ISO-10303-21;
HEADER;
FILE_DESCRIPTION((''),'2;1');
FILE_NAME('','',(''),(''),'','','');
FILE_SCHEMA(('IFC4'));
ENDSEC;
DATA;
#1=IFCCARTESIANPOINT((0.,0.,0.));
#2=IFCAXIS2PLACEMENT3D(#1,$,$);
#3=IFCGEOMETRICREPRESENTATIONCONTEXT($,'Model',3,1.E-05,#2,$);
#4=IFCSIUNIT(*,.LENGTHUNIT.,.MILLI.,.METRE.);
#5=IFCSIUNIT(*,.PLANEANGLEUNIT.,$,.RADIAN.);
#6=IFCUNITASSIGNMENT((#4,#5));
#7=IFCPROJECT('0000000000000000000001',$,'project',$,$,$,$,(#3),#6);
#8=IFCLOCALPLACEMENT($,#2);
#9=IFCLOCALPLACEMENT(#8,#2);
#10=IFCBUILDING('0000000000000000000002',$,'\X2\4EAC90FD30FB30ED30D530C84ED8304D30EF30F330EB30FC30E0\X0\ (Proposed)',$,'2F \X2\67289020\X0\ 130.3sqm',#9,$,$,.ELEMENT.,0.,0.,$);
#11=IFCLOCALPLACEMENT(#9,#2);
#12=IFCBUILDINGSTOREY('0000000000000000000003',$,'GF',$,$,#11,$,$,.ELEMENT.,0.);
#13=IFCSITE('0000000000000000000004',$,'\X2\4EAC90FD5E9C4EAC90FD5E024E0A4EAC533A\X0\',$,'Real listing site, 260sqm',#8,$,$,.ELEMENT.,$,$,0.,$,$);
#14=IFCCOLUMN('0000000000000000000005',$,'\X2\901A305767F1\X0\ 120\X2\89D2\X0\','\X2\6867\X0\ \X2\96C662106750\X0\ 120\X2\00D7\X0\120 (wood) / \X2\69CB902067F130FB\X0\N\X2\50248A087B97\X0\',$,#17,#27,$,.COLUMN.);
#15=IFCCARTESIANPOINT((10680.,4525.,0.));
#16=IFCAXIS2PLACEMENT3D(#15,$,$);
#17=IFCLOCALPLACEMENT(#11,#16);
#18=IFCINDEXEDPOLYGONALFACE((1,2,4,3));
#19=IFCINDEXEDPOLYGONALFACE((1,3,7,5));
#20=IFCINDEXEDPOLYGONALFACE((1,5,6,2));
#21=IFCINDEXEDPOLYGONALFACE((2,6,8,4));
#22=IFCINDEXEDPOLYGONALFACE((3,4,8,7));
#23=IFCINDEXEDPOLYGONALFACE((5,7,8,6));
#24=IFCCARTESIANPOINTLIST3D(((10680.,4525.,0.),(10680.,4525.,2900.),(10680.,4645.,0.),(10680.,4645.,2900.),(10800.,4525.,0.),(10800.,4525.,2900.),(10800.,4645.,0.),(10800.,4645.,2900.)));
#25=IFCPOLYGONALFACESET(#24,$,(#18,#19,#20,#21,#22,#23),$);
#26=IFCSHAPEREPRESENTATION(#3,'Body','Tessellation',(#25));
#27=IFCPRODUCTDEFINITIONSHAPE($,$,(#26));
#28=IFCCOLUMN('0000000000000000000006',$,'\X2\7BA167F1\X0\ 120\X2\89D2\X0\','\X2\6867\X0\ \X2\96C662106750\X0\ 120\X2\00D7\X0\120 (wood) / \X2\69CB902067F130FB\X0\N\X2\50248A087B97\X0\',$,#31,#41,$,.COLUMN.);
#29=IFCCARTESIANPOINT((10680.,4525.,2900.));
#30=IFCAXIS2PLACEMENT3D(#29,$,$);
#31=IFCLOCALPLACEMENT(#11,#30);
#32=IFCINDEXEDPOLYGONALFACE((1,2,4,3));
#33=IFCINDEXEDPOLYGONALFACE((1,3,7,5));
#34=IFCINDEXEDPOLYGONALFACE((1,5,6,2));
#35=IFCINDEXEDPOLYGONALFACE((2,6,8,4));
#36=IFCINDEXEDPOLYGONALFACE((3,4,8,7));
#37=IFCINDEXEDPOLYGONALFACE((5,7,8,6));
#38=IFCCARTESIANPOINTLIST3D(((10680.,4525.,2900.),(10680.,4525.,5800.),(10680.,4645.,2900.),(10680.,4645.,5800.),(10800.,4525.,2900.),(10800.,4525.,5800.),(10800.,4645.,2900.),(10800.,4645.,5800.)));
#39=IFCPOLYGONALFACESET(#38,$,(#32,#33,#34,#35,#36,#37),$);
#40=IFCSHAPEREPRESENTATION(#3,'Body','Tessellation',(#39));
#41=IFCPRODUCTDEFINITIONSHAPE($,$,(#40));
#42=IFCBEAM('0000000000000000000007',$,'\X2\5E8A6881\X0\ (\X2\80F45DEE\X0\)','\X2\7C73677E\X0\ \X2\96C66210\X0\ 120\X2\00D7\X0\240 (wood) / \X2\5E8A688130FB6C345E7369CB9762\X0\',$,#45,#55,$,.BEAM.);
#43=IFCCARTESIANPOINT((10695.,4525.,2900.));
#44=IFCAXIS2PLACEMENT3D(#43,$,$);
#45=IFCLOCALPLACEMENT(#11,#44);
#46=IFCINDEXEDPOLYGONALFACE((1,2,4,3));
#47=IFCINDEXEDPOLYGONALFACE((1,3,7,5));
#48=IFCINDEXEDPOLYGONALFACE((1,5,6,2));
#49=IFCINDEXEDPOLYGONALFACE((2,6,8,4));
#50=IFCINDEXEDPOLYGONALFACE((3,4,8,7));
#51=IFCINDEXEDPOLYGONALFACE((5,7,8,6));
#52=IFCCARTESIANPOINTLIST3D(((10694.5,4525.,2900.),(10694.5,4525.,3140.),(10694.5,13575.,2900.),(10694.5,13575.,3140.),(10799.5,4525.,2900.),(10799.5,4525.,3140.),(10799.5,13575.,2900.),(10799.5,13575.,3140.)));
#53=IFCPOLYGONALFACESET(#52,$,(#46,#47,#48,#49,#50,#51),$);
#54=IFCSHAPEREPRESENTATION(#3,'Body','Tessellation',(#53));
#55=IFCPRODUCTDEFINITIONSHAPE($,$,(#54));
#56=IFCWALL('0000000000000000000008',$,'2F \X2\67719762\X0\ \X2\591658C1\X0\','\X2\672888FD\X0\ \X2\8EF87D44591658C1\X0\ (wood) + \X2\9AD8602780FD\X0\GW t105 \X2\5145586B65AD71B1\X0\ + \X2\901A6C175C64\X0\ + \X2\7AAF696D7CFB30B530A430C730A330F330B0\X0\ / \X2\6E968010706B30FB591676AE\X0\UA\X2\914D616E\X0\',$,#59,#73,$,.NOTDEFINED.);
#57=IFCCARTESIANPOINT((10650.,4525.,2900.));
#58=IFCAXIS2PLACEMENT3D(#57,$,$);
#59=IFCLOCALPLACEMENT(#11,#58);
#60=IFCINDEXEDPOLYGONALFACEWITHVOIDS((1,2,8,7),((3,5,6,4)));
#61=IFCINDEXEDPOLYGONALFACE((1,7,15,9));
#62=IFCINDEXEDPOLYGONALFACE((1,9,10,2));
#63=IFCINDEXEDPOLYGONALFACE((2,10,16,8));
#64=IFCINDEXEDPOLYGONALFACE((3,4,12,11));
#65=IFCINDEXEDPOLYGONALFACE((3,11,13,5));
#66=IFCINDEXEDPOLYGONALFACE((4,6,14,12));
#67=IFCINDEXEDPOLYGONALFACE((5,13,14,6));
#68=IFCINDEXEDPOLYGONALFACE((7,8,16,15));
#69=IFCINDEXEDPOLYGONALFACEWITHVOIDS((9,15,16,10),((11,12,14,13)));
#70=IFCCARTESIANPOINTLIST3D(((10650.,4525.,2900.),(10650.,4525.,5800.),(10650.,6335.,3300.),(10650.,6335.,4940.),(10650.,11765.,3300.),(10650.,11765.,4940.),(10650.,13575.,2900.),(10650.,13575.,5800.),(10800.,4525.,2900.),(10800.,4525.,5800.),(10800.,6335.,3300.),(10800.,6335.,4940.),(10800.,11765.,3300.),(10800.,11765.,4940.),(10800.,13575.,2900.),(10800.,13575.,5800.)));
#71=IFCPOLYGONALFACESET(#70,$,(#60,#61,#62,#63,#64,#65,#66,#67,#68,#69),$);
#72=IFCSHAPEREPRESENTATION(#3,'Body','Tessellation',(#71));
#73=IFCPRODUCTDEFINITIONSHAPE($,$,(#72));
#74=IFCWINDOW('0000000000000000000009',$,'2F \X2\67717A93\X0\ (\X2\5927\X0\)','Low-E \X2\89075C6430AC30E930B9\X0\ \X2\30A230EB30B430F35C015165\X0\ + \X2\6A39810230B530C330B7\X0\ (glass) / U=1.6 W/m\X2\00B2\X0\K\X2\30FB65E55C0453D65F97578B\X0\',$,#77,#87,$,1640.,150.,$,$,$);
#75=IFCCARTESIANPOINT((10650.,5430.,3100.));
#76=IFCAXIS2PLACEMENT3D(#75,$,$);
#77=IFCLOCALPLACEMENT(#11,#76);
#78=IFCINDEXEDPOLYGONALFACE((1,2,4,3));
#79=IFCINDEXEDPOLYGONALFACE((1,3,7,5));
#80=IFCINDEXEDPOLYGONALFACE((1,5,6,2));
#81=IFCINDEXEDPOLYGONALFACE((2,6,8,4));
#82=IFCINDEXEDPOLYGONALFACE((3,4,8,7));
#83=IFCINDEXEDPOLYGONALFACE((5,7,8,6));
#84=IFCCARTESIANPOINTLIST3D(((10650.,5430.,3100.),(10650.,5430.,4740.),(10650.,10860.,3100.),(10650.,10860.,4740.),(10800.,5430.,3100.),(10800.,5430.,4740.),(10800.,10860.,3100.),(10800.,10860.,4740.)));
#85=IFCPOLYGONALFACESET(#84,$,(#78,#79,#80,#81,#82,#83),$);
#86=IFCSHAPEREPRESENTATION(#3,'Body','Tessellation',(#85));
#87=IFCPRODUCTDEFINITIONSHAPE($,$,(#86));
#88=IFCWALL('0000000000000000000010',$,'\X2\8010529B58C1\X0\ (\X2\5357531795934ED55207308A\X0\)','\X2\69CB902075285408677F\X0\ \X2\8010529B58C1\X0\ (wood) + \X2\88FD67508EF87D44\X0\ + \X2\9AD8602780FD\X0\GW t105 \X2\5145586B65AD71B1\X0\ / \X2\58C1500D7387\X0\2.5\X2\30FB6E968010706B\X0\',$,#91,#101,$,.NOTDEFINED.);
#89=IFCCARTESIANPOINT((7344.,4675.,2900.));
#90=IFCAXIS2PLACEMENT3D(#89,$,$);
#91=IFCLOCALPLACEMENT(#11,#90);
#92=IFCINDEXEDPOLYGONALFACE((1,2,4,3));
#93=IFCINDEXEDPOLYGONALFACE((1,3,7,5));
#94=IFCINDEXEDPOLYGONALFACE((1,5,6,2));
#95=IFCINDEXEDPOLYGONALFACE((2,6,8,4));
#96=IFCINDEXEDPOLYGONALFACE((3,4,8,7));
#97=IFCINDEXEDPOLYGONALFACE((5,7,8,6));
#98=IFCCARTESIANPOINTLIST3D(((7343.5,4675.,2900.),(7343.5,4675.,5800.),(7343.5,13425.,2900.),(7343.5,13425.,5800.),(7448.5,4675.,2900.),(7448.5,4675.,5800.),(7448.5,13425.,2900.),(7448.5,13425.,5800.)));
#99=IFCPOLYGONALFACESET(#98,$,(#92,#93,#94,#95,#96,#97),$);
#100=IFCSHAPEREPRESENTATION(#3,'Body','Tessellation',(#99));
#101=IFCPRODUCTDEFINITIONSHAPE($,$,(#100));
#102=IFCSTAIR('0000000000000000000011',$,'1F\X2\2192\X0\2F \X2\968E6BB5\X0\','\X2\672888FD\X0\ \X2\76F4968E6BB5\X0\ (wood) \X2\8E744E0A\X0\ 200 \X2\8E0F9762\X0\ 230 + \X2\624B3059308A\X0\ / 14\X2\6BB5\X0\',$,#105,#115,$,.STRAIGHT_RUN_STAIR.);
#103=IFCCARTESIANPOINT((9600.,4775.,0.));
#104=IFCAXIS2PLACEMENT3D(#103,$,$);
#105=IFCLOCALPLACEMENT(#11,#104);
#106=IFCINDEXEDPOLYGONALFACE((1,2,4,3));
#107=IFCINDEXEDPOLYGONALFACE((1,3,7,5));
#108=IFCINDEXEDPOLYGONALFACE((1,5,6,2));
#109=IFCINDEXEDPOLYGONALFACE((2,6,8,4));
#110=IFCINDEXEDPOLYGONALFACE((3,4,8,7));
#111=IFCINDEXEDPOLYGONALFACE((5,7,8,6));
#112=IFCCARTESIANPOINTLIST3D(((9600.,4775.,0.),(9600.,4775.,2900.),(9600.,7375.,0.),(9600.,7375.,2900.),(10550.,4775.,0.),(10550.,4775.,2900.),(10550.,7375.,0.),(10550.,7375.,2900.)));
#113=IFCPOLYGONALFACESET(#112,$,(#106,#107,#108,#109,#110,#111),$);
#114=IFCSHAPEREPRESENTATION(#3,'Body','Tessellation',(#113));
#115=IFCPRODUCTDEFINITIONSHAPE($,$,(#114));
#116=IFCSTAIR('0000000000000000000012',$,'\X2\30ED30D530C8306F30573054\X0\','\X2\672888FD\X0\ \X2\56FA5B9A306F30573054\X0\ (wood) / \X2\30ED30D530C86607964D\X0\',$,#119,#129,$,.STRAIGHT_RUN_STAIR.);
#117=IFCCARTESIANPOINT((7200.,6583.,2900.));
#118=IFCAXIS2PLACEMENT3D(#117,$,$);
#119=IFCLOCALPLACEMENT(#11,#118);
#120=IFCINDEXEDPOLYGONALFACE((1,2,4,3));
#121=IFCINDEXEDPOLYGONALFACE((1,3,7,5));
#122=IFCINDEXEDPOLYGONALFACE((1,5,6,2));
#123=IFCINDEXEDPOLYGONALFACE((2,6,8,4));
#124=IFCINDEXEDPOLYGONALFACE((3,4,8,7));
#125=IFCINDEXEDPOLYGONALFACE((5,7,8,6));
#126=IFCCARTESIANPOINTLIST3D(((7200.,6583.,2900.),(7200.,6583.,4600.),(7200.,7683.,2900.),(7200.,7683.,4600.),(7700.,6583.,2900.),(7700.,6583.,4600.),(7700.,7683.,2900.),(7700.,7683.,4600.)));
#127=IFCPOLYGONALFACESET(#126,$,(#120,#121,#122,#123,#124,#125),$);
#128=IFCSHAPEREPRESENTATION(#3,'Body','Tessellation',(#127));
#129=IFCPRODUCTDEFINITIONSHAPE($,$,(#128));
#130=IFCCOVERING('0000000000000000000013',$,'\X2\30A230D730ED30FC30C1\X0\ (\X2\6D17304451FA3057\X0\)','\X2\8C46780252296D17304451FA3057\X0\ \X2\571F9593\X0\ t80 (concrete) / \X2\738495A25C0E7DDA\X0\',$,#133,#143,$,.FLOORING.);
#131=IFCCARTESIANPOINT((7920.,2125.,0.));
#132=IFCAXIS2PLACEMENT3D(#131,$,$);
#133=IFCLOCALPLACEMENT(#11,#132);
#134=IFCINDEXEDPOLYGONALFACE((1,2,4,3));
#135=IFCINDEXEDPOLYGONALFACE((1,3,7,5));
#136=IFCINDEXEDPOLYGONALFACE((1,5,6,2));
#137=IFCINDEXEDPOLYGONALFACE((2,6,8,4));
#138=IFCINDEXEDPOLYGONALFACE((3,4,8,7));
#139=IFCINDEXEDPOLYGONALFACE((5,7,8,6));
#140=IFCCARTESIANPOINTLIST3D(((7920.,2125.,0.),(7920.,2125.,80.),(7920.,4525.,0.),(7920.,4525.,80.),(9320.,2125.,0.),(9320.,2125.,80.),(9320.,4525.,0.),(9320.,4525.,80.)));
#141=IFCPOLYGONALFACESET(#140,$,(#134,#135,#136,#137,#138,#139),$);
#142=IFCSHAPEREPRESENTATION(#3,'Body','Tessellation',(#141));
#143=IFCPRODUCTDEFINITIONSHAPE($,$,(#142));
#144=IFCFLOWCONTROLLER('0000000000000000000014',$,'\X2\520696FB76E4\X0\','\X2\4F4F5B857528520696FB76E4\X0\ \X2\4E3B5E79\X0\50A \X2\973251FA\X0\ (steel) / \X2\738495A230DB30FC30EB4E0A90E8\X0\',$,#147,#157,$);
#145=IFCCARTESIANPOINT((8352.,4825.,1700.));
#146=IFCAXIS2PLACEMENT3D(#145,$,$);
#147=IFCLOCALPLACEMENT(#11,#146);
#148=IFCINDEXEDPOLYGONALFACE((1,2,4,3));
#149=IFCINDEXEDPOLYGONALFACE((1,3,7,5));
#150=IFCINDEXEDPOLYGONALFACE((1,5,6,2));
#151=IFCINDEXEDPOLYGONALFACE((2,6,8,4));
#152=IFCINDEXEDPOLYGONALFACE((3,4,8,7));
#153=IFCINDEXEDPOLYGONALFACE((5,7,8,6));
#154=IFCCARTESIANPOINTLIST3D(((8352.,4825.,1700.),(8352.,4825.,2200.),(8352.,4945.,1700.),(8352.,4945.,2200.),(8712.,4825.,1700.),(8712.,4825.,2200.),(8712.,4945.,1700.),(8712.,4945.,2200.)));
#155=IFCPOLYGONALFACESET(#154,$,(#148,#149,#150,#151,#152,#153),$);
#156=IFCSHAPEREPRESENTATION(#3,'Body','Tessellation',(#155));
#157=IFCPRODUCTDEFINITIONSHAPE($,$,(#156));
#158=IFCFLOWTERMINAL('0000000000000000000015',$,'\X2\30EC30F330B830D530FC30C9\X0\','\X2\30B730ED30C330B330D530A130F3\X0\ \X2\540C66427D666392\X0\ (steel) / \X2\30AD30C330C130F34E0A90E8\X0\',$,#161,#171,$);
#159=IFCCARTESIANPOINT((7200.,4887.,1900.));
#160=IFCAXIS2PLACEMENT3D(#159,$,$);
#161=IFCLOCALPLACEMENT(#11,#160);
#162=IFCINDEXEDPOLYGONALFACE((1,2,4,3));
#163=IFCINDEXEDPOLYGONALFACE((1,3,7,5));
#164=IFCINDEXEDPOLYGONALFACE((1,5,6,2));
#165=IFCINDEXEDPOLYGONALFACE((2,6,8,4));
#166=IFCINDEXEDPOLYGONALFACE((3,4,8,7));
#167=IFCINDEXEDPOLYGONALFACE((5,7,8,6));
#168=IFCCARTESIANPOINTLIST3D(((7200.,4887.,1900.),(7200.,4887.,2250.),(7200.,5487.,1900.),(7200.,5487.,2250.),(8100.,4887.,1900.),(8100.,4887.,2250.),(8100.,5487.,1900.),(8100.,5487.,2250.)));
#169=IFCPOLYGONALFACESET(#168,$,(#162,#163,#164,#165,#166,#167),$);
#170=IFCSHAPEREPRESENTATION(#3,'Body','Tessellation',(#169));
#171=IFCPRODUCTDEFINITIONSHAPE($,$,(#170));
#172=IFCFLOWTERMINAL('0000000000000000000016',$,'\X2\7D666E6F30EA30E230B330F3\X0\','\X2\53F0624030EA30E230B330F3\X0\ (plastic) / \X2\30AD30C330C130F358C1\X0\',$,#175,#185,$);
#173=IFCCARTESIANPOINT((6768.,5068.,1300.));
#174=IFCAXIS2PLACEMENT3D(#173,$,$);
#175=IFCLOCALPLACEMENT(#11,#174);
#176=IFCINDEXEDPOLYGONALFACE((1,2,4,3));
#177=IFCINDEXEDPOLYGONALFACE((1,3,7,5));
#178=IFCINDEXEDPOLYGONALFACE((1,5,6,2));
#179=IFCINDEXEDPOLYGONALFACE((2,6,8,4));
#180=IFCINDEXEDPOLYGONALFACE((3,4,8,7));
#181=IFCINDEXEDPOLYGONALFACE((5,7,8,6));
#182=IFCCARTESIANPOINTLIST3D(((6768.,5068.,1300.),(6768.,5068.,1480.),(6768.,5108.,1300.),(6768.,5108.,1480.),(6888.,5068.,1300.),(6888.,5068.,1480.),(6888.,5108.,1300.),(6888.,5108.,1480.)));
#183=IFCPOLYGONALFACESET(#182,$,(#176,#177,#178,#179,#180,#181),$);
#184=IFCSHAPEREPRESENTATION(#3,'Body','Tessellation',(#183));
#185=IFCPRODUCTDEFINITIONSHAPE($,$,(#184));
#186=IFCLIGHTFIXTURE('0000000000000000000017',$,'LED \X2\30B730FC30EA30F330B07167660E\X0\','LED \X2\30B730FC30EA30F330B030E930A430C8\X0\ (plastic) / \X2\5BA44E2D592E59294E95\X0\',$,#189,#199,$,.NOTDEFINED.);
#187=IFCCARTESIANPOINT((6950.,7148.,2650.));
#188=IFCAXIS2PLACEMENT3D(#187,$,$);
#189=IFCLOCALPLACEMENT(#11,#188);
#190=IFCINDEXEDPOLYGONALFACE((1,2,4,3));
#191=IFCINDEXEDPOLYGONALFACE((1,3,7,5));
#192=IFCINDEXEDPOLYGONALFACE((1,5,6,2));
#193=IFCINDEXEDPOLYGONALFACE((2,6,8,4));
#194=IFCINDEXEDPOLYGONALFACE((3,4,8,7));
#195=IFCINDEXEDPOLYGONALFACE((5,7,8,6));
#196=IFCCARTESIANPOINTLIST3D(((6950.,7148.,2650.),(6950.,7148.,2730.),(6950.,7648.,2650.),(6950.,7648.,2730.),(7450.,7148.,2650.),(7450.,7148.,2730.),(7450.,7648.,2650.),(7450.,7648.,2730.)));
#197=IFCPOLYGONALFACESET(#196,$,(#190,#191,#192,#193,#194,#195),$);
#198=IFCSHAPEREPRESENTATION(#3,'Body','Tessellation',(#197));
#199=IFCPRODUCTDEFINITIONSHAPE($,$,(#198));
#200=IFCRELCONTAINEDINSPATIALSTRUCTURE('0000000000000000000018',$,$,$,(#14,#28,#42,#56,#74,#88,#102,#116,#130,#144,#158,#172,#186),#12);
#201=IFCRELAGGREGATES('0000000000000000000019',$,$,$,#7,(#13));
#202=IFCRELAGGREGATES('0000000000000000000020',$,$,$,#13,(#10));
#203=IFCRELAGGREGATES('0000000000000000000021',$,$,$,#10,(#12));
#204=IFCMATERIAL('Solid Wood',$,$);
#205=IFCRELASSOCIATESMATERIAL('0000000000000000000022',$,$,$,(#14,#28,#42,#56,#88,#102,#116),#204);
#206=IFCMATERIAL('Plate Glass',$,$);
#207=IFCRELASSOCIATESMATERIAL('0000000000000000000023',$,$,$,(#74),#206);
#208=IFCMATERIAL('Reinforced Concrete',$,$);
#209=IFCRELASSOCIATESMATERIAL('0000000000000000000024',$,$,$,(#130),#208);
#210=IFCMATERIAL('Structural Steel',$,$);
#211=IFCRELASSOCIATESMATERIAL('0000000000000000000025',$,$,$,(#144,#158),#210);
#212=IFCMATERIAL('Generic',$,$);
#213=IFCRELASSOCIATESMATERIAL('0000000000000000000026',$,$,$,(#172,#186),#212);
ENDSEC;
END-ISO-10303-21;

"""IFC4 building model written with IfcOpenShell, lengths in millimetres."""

from ifc_helpers import new_model, si_unit, frame, frame_2d, origin, place, context, project, spatial, rectangle, extrude, material, element, fill, save


model = new_model("IFC4")

# Units and contexts
model_context = context("Model", 3, precision=1e-05, world=origin())
ifc_project = project(units=[si_unit("LENGTHUNIT", "METRE", prefix="MILLI"), si_unit("PLANEANGLEUNIT", "RADIAN")], contexts=[model_context])

# Site, building, storey
site_placement = place(None, origin())
site = spatial("IfcSite", under=ifc_project, at=site_placement, Name="京都府京都市上京区", ObjectType="Real listing site, 260sqm", CompositionType="ELEMENT", RefElevation=0.0)
building_placement = place(site_placement, origin())
building = spatial("IfcBuilding", under=site, at=building_placement, Name="京都・ロフト付きワンルーム (Proposed)", ObjectType="2F 木造 130.3sqm", CompositionType="ELEMENT", ElevationOfRefHeight=0.0, ElevationOfTerrain=0.0)
storey_placement = place(building_placement, origin())
storey = spatial("IfcBuildingStorey", under=building, at=storey_placement, Name="GF", CompositionType="ELEMENT", Elevation=0.0)

# Columns
ifc_material_1 = material(Name="Solid Wood")
column_1_placement = place(storey_placement, frame((10680.0, 4525.0, 0.0)))
element("IfcColumn", 1, at=column_1_placement, inside=storey, material=ifc_material_1, Name="通し柱 120角", Description="桧 集成材 120×120 (wood) / 構造柱・N値計算", PredefinedType="COLUMN", context=model_context, shape_type="SweptSolid", body=[
    extrude(rectangle(XDim=120.0, YDim=120.0, at=frame_2d((60.0, 60.0))), frame((10680.0, 4525.0, 0.0)), (0.0, 0.0, 1.0), 2900.0),
])
column_2_placement = place(storey_placement, frame((10680.0, 4525.0, 2900.0)))
element("IfcColumn", 2, at=column_2_placement, inside=storey, material=ifc_material_1, Name="管柱 120角", Description="桧 集成材 120×120 (wood) / 構造柱・N値計算", PredefinedType="COLUMN", context=model_context, shape_type="SweptSolid", body=[
    extrude(rectangle(XDim=120.0, YDim=120.0, at=frame_2d((60.0, 60.0))), frame((10680.0, 4525.0, 2900.0)), (0.0, 0.0, 1.0), 2900.0),
])

# Beam
beam_1_placement = place(storey_placement, frame((10695.0, 4525.0, 2900.0)))
element("IfcBeam", 3, at=beam_1_placement, inside=storey, material=ifc_material_1, Name="床梁 (胴差)", Description="米松 集成 120×240 (wood) / 床梁・水平構面", PredefinedType="BEAM", context=model_context, shape_type="SweptSolid", body=[
    extrude(rectangle(XDim=105.0, YDim=9050.0, at=frame_2d((52.0, 4525.0))), frame((10695.0, 4525.0, 2900.0)), (0.0, 0.0, 1.0), 240.0),
])

# Shared definitions
ifc_material_2 = material(Name="Plate Glass")

# Wall, opening, window
wall_1_placement = place(storey_placement, frame((10650.0, 4525.0, 2900.0)))
wall_1 = element("IfcWall", 4, at=wall_1_placement, inside=storey, material=ifc_material_1, Name="2F 東面 外壁", Description="木製 軸組外壁 (wood) + 高性能GW t105 充填断熱 + 通気層 + 窯業系サイディング / 準耐火・外皮UA配慮", PredefinedType="NOTDEFINED", context=model_context, shape_type="SweptSolid", body=[
    extrude(rectangle(XDim=150.0, YDim=9050.0, at=frame_2d((75.0, 4525.0))), frame((10650.0, 4525.0, 2900.0)), (0.0, 0.0, 1.0), 2900.0),
])
opening_1_placement = place(storey_placement, frame((10650.0, 5430.0, 3100.0)))
opening_1 = element("IfcOpeningElement", 5, at=opening_1_placement, cuts=wall_1, PredefinedType="NOTDEFINED", context=model_context, shape_type="SweptSolid", body=[
    extrude(rectangle(XDim=150.0, YDim=5430.0, at=frame_2d((75.0, 2715.0))), frame((10650.0, 5430.0, 3100.0)), (0.0, 0.0, 1.0), 1640.0),
])
window_1_placement = place(storey_placement, frame((10650.0, 5430.0, 3100.0)))
window_1 = element("IfcWindow", 6, at=window_1_placement, inside=storey, material=ifc_material_2, Name="2F 東窓 (大)", Description="Low-E 複層ガラス アルゴン封入 + 樹脂サッシ (glass) / U=1.6 W/m²K・日射取得型", OverallHeight=1640.0, OverallWidth=150.0, context=model_context, shape_type="SweptSolid", body=[
    extrude(rectangle(XDim=150.0, YDim=5430.0, at=frame_2d((75.0, 2715.0))), frame((10650.0, 5430.0, 3100.0)), (0.0, 0.0, 1.0), 1640.0),
])
fill(opening_1, window_1)

# Wall
wall_2_placement = place(storey_placement, frame((7344.0, 4675.0, 2900.0)))
element("IfcWall", 7, at=wall_2_placement, inside=storey, material=ifc_material_1, Name="耐力壁 (南北間仕切り)", Description="構造用合板 耐力壁 (wood) + 製材軸組 + 高性能GW t105 充填断熱 / 壁倍率2.5・準耐火", PredefinedType="NOTDEFINED", context=model_context, shape_type="SweptSolid", body=[
    extrude(rectangle(XDim=105.0, YDim=8750.0, at=frame_2d((52.0, 4375.0))), frame((7344.0, 4675.0, 2900.0)), (0.0, 0.0, 1.0), 2900.0),
])

# Stairs
stair_1_placement = place(storey_placement, frame((9600.0, 4775.0, 0.0)))
element("IfcStair", 8, at=stair_1_placement, inside=storey, material=ifc_material_1, Name="1F→2F 階段", Description="木製 直階段 (wood) 蹴上 200 踏面 230 + 手すり / 14段", PredefinedType="STRAIGHT_RUN_STAIR", context=model_context, shape_type="SweptSolid", body=[
    extrude(rectangle(XDim=950.0, YDim=2600.0, at=frame_2d((475.0, 1300.0))), frame((9600.0, 4775.0, 0.0)), (0.0, 0.0, 1.0), 2900.0),
])
stair_2_placement = place(storey_placement, frame((7200.0, 6583.0, 2900.0)))
element("IfcStair", 9, at=stair_2_placement, inside=storey, material=ifc_material_1, Name="ロフトはしご", Description="木製 固定はしご (wood) / ロフト昇降", PredefinedType="STRAIGHT_RUN_STAIR", context=model_context, shape_type="SweptSolid", body=[
    extrude(rectangle(XDim=500.0, YDim=1100.0, at=frame_2d((250.0, 550.0))), frame((7200.0, 6583.0, 2900.0)), (0.0, 0.0, 1.0), 1700.0),
])

# Covering
ifc_material_3 = material(Name="Reinforced Concrete")
covering_placement = place(storey_placement, frame((7920.0, 2125.0, 0.0)))
element("IfcCovering", 10, at=covering_placement, inside=storey, material=ifc_material_3, Name="アプローチ (洗い出し)", Description="豆砂利洗い出し 土間 t80 (concrete) / 玄関導線", PredefinedType="FLOORING", context=model_context, shape_type="SweptSolid", body=[
    extrude(rectangle(XDim=1400.0, YDim=2400.0, at=frame_2d((700.0, 1200.0))), frame((7920.0, 2125.0, 0.0)), (0.0, 0.0, 1.0), 80.0),
])

# Flow controller
ifc_material_4 = material(Name="Structural Steel")
flow_controller_placement = place(storey_placement, frame((8352.0, 4825.0, 1700.0)))
element("IfcFlowController", 11, at=flow_controller_placement, inside=storey, material=ifc_material_4, Name="分電盤", Description="住宅用分電盤 主幹50A 露出 (steel) / 玄関ホール上部", context=model_context, shape_type="SweptSolid", body=[
    extrude(rectangle(XDim=360.0, YDim=120.0, at=frame_2d((180.0, 60.0))), frame((8352.0, 4825.0, 1700.0)), (0.0, 0.0, 1.0), 500.0),
])

# Flow terminals
flow_terminal_1_placement = place(storey_placement, frame((7200.0, 4887.0, 1900.0)))
element("IfcFlowTerminal", 12, at=flow_terminal_1_placement, inside=storey, material=ifc_material_4, Name="レンジフード", Description="シロッコファン 同時給排 (steel) / キッチン上部", context=model_context, shape_type="SweptSolid", body=[
    extrude(rectangle(XDim=900.0, YDim=600.0, at=frame_2d((450.0, 300.0))), frame((7200.0, 4887.0, 1900.0)), (0.0, 0.0, 1.0), 350.0),
])
ifc_material_5 = material(Name="Generic")
flow_terminal_2_placement = place(storey_placement, frame((6768.0, 5068.0, 1300.0)))
element("IfcFlowTerminal", 13, at=flow_terminal_2_placement, inside=storey, material=ifc_material_5, Name="給湯リモコン", Description="台所リモコン (plastic) / キッチン壁", context=model_context, shape_type="SweptSolid", body=[
    extrude(rectangle(XDim=120.0, YDim=40.0, at=frame_2d((60.0, 20.0))), frame((6768.0, 5068.0, 1300.0)), (0.0, 0.0, 1.0), 180.0),
])

# Light fixture
light_fixture_1_placement = place(storey_placement, frame((6950.0, 7148.0, 2650.0)))
element("IfcLightFixture", 14, at=light_fixture_1_placement, inside=storey, material=ifc_material_5, Name="LED シーリング照明", Description="LED シーリングライト (plastic) / 室中央天井", PredefinedType="NOTDEFINED", context=model_context, shape_type="SweptSolid", body=[
    extrude(rectangle(XDim=500.0, YDim=500.0, at=frame_2d((250.0, 250.0))), frame((6950.0, 7148.0, 2650.0)), (0.0, 0.0, 1.0), 80.0),
])

save(model, "model.ifc")
